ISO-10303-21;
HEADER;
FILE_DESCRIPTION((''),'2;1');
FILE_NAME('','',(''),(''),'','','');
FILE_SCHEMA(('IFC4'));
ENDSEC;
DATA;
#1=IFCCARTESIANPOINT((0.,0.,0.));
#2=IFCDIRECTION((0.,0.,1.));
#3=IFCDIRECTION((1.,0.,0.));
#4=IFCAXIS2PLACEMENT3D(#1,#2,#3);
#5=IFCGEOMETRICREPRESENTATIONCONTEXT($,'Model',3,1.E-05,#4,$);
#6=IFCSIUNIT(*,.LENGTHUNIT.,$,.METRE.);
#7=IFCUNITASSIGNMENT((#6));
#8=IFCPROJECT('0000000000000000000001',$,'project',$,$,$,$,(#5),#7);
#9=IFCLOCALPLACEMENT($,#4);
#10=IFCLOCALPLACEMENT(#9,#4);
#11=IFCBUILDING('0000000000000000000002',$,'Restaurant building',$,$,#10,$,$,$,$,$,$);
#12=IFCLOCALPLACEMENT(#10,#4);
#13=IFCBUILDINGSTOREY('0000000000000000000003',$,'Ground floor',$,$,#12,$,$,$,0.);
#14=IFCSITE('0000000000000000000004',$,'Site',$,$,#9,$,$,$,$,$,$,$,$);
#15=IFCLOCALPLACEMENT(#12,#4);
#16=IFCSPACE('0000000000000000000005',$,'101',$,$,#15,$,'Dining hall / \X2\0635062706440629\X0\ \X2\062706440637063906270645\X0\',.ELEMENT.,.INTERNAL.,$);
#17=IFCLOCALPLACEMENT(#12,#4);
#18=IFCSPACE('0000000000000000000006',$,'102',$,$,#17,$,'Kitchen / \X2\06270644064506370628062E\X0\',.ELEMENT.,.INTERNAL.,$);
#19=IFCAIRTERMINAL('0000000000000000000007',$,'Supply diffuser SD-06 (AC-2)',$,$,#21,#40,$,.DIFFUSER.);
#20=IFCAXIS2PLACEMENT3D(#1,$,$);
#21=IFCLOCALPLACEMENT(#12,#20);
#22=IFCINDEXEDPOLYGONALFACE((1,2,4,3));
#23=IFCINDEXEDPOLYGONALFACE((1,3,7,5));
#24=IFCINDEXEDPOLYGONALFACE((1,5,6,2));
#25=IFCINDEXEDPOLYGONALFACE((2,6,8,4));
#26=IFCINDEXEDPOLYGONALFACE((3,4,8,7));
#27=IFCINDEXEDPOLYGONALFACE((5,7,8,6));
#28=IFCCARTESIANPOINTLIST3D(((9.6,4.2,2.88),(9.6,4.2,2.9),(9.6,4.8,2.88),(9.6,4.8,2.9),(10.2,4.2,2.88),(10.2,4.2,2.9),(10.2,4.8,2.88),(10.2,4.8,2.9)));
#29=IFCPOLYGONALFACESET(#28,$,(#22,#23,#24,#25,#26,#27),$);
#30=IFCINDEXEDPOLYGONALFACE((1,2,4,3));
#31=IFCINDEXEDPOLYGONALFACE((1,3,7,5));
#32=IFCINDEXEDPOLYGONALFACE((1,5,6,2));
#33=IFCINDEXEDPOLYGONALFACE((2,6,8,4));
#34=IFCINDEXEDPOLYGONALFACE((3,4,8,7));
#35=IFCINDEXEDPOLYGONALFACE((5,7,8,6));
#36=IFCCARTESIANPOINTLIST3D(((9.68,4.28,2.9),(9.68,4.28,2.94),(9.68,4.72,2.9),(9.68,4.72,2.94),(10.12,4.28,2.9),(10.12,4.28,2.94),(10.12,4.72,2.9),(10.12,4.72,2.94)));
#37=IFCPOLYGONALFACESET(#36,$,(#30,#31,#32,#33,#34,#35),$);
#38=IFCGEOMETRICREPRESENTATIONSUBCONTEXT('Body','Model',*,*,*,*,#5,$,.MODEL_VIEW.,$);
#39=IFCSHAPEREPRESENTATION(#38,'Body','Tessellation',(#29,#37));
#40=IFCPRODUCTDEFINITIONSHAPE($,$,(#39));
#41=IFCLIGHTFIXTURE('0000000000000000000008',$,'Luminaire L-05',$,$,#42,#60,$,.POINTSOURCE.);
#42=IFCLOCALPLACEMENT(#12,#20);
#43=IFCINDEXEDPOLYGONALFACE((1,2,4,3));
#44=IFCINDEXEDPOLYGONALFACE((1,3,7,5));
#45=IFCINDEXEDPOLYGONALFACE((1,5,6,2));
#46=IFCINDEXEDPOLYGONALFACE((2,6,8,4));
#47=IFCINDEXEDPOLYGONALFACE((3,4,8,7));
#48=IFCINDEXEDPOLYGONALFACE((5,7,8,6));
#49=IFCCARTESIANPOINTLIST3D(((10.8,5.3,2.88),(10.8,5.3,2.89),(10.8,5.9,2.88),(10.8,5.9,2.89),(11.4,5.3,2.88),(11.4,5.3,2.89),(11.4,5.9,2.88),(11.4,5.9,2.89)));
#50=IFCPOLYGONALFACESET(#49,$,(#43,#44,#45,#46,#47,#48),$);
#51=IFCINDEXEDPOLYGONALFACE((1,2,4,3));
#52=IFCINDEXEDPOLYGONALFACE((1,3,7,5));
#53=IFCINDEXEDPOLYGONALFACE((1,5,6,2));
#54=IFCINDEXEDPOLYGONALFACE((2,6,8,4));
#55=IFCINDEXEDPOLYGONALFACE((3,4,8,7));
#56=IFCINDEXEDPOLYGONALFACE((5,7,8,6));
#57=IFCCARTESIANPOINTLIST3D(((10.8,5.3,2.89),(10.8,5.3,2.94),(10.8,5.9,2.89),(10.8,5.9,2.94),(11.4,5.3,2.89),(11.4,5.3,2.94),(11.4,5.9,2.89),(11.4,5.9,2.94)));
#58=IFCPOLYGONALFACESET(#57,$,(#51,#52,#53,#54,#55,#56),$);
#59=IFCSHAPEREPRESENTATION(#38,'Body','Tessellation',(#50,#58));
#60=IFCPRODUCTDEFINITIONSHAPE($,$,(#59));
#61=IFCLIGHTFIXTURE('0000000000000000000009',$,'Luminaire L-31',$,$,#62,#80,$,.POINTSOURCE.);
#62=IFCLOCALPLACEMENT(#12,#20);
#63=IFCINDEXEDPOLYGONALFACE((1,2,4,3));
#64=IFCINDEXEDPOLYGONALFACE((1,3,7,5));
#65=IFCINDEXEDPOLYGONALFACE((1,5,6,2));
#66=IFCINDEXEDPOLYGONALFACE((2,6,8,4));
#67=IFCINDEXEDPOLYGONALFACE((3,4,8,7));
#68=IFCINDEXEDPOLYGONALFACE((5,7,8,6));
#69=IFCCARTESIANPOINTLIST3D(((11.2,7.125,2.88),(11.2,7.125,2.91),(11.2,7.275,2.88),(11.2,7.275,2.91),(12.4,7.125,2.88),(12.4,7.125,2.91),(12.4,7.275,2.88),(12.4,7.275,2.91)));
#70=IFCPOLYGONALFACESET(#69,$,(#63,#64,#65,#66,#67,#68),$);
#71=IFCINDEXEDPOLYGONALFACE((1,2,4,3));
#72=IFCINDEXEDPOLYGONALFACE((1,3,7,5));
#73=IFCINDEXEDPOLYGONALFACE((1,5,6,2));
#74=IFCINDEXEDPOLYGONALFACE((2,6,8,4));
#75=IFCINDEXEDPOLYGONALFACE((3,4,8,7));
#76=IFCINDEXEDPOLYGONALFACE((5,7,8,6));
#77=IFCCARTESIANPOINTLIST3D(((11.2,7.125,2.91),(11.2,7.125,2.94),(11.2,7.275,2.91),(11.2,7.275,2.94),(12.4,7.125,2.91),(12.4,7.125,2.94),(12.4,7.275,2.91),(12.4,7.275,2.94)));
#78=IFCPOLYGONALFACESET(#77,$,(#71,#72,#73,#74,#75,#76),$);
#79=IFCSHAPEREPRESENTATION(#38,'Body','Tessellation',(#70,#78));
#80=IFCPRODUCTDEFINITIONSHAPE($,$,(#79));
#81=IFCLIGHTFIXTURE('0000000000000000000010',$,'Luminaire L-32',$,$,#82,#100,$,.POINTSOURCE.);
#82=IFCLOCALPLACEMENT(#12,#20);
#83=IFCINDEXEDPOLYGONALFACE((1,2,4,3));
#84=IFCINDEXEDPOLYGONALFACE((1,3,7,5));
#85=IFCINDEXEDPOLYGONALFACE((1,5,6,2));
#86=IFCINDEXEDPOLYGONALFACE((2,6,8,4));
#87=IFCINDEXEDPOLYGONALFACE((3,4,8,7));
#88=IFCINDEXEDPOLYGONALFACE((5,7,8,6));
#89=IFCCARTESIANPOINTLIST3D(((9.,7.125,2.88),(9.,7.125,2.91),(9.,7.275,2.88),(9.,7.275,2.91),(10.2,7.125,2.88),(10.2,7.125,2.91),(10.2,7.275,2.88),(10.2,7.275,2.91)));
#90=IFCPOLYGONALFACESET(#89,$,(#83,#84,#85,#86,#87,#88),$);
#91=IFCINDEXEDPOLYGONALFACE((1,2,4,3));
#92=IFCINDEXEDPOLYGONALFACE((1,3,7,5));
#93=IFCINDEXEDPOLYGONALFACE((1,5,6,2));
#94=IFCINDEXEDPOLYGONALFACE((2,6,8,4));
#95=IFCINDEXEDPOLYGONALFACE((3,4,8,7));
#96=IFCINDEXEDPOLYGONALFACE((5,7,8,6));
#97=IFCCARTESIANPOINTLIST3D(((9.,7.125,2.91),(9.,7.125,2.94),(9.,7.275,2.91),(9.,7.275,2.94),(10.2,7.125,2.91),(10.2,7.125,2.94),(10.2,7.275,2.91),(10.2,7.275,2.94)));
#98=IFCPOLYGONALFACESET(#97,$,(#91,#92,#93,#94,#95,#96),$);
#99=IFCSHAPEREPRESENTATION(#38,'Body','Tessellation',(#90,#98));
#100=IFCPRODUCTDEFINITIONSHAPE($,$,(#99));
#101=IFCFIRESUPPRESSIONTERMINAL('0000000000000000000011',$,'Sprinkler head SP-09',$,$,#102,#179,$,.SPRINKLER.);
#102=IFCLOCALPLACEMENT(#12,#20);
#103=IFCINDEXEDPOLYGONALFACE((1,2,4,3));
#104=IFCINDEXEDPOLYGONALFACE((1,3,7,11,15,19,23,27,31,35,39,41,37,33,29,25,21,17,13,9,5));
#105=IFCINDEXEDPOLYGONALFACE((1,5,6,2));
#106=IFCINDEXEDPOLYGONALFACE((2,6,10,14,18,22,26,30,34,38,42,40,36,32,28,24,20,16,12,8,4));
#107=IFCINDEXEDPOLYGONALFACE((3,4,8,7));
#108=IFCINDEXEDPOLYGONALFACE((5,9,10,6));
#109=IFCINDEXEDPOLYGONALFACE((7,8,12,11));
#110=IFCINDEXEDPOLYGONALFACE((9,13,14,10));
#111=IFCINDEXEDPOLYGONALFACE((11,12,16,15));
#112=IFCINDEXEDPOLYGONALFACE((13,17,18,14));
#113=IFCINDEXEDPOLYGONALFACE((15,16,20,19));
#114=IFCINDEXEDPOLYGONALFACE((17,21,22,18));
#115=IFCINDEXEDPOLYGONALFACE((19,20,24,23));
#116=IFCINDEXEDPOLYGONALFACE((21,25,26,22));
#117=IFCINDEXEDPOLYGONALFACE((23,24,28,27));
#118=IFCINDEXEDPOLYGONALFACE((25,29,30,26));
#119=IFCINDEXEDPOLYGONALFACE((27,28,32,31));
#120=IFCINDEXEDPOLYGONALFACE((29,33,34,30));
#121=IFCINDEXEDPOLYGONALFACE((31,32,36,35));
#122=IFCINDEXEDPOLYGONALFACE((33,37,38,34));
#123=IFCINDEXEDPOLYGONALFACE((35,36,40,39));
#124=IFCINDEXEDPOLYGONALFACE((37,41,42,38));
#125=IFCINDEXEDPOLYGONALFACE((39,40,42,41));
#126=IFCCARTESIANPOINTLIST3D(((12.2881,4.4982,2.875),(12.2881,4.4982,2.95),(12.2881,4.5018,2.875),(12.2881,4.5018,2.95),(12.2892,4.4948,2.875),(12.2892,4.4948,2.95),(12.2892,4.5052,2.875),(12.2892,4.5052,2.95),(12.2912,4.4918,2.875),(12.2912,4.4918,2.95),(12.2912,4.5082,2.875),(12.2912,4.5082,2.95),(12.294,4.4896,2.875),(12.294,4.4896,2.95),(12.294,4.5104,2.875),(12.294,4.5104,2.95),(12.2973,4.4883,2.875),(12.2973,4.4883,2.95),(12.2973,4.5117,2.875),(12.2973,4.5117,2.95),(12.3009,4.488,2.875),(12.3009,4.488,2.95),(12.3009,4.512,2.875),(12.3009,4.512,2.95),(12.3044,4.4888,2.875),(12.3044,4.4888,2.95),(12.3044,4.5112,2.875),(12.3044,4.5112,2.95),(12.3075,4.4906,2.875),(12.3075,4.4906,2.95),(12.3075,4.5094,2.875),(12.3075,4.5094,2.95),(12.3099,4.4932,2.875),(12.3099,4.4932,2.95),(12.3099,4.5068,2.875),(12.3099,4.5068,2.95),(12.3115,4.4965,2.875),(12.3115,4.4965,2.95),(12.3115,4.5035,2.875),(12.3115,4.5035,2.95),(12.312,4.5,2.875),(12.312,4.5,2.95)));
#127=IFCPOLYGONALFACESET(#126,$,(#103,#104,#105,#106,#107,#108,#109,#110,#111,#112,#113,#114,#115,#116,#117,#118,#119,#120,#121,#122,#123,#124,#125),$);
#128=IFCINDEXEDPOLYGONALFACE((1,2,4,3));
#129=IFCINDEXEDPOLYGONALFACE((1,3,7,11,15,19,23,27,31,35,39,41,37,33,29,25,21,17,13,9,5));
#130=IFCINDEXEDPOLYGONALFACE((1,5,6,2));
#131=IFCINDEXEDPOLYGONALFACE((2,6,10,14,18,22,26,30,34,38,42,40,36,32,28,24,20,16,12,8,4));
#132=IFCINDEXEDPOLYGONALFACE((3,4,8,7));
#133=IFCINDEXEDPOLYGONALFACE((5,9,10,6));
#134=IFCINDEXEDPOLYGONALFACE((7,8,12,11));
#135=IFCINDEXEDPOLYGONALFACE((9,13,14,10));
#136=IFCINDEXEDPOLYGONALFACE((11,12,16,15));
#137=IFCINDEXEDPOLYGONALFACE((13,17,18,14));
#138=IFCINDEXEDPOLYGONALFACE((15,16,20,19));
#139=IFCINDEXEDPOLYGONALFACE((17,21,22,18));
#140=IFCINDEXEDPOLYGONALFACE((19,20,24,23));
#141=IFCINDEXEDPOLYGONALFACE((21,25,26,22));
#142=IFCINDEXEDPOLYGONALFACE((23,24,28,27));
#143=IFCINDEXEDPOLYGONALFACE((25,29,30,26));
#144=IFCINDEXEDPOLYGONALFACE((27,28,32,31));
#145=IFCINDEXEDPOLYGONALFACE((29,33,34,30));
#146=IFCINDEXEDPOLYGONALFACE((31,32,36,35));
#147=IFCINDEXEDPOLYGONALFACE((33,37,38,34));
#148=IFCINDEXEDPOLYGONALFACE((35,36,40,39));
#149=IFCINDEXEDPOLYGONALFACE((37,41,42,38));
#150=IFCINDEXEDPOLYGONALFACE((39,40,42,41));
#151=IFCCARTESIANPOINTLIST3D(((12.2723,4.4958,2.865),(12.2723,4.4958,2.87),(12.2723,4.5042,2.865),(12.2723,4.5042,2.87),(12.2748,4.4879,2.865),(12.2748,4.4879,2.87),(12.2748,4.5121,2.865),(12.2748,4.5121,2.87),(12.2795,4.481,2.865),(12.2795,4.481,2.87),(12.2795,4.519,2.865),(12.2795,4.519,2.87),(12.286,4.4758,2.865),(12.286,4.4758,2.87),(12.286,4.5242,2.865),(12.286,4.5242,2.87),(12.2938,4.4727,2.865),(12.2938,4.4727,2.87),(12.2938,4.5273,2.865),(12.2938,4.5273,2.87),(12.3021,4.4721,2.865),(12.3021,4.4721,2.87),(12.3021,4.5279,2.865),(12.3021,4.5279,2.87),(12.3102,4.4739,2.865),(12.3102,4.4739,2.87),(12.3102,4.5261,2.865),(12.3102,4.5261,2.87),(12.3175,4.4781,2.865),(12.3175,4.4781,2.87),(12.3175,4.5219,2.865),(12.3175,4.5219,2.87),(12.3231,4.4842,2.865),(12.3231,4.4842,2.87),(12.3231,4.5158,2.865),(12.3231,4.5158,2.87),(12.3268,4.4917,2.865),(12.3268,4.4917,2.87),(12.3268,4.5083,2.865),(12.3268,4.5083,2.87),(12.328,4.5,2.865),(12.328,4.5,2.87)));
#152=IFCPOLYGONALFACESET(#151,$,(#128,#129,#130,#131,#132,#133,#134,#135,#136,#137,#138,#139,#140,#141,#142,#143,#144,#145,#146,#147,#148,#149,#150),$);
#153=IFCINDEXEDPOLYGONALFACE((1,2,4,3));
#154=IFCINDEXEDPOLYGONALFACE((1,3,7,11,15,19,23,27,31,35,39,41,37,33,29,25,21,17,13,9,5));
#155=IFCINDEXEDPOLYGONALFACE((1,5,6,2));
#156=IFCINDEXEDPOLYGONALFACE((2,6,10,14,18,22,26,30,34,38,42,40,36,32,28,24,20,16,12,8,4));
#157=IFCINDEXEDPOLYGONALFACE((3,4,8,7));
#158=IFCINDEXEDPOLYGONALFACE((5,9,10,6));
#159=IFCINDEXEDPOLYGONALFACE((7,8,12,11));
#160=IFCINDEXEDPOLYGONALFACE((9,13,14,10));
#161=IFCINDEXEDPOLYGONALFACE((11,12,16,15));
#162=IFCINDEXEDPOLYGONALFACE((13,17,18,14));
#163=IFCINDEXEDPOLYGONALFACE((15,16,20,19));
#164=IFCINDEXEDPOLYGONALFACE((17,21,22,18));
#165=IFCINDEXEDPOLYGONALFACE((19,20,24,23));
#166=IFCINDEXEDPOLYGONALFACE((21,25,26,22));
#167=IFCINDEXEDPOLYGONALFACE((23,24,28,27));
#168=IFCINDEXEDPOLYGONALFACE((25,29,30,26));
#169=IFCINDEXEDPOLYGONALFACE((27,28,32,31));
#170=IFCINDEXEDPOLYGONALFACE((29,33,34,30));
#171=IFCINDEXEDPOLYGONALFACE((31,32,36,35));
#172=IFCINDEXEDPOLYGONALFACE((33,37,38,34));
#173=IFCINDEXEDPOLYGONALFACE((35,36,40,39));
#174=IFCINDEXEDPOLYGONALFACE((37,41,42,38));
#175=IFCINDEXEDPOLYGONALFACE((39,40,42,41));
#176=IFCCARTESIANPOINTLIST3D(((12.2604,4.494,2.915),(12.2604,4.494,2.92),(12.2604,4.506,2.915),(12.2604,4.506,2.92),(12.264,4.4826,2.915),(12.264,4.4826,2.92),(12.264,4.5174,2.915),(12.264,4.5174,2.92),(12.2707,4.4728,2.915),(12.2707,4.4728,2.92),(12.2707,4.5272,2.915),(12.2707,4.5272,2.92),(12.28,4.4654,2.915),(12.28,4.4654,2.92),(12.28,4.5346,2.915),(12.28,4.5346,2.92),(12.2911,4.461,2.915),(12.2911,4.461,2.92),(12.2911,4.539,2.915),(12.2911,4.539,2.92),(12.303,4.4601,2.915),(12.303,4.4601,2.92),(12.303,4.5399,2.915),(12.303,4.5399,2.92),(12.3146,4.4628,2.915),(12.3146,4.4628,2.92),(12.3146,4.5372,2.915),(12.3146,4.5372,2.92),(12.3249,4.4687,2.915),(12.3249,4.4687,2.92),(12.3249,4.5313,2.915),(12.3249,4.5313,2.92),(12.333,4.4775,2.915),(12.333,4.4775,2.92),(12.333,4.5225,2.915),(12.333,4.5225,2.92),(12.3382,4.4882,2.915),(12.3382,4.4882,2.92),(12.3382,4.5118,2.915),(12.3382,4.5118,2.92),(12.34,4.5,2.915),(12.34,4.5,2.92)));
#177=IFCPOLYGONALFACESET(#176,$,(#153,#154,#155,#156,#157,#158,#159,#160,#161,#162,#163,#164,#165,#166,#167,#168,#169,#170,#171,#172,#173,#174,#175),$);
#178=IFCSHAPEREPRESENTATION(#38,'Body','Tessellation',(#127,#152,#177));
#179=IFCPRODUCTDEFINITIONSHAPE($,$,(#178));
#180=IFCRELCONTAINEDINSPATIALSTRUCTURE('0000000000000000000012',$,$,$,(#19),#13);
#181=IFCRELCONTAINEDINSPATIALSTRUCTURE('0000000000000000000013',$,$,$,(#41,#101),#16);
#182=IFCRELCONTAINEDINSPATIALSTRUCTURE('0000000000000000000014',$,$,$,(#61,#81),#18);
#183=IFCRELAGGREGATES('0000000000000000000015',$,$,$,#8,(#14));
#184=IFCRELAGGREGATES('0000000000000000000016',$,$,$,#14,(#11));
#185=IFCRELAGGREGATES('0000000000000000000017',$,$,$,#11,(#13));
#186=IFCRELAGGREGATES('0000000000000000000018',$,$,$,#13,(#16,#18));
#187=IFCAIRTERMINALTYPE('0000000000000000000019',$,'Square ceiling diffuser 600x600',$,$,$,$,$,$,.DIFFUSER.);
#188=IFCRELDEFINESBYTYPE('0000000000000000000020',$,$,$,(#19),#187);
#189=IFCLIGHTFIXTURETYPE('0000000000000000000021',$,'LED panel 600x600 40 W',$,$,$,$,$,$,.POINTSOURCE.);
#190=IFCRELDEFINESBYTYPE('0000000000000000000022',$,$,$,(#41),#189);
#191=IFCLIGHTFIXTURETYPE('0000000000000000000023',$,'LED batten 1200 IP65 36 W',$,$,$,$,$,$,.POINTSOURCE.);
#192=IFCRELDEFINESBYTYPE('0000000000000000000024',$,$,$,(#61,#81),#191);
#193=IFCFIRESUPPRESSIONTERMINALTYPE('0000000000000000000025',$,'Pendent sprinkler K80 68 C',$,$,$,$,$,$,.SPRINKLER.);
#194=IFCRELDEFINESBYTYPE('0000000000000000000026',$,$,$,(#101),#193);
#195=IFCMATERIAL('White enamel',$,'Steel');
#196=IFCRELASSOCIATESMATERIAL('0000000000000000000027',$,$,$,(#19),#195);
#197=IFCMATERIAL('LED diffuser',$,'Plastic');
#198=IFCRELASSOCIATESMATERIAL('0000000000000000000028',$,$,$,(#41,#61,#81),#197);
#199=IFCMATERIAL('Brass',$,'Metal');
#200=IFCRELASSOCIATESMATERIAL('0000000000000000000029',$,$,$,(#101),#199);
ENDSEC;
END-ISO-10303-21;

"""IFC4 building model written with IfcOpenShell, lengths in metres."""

from ifc_helpers import new_model, si_unit, frame, origin, origin_with_axes, origin_2d, place, context, subcontext, project, spatial, rectangle, circle, extrude, source, transform, mapped, material, type_object, type_shapes, element, save


model = new_model("IFC4")

# Units and contexts
model_context = context("Model", 3, precision=1e-05, world=origin_with_axes())
body_context = subcontext(model_context, "Body", "Model", "MODEL_VIEW")
ifc_project = project(units=[si_unit("LENGTHUNIT", "METRE")], contexts=[model_context])

# Site, building, storey
site_placement = place(None, origin_with_axes())
site = spatial("IfcSite", under=ifc_project, at=site_placement, Name="Site")
building_placement = place(site_placement, origin_with_axes())
building = spatial("IfcBuilding", under=site, at=building_placement, Name="Restaurant building")
storey_placement = place(building_placement, origin_with_axes())
storey = spatial("IfcBuildingStorey", under=building, at=storey_placement, Name="Ground floor", Elevation=0.0)

# Air terminal
ifc_material_1 = material(Name="White enamel", Category="Steel")
air_terminal_type = type_object("IfcAirTerminalType", Name="Square ceiling diffuser 600x600", PredefinedType="DIFFUSER")
shared_shape_1 = source(origin(), body_context, "Body", "SweptSolid", [
    extrude(rectangle(XDim=0.6, YDim=0.6, at=origin_2d()), frame((0.0, 0.0, -0.06)), (0.0, 0.0, 1.0), 0.02),
    extrude(rectangle(XDim=0.44, YDim=0.44, at=origin_2d()), frame((0.0, 0.0, -0.04)), (0.0, 0.0, 1.0), 0.04),
])
type_shapes(air_terminal_type, [shared_shape_1])
air_terminal_placement = place(storey_placement, frame((9.9, 4.5, 2.94)))
element("IfcAirTerminal", 1, at=air_terminal_placement, inside=storey, type_object=air_terminal_type, material=ifc_material_1, Name="Supply diffuser SD-06 (AC-2)", PredefinedType="DIFFUSER", context=body_context, shape_type="MappedRepresentation", body=[
    mapped(shared_shape_1, transform((0.0, 0.0, 0.0))),
])

# Shared definitions
space_1_placement = place(storey_placement, origin_with_axes())
space_1 = spatial("IfcSpace", under=storey, at=space_1_placement, Name="101", LongName="Dining hall / صالة الطعام", CompositionType="ELEMENT", PredefinedType="INTERNAL")

# Light fixture
ifc_material_2 = material(Name="LED diffuser", Category="Plastic")
light_fixture_type_1 = type_object("IfcLightFixtureType", Name="LED panel 600x600 40 W", PredefinedType="POINTSOURCE")
shared_shape_2 = source(origin(), body_context, "Body", "SweptSolid", [
    extrude(rectangle(XDim=0.6, YDim=0.6, at=origin_2d()), frame((0.0, 0.0, -0.06)), (0.0, 0.0, 1.0), 0.01),
    extrude(rectangle(XDim=0.6, YDim=0.6, at=origin_2d()), frame((0.0, 0.0, -0.05)), (0.0, 0.0, 1.0), 0.05),
])
type_shapes(light_fixture_type_1, [shared_shape_2])
light_fixture_placement = place(storey_placement, frame((11.1, 5.6, 2.94)))
element("IfcLightFixture", 2, at=light_fixture_placement, inside=space_1, type_object=light_fixture_type_1, material=ifc_material_2, Name="Luminaire L-05", PredefinedType="POINTSOURCE", context=body_context, shape_type="MappedRepresentation", body=[
    mapped(shared_shape_2, transform((0.0, 0.0, 0.0))),
])

# Shared definitions
space_2_placement = place(storey_placement, origin_with_axes())
space_2 = spatial("IfcSpace", under=storey, at=space_2_placement, Name="102", LongName="Kitchen / المطبخ", CompositionType="ELEMENT", PredefinedType="INTERNAL")

# Light fixtures
light_fixture_type_2 = type_object("IfcLightFixtureType", Name="LED batten 1200 IP65 36 W", PredefinedType="POINTSOURCE")
shared_shape_3 = source(origin(), body_context, "Body", "SweptSolid", [
    extrude(rectangle(XDim=1.2, YDim=0.15, at=origin_2d()), frame((0.0, 0.0, -0.06)), (0.0, 0.0, 1.0), 0.03),
    extrude(rectangle(XDim=1.2, YDim=0.15, at=origin_2d()), frame((0.0, 0.0, -0.03)), (0.0, 0.0, 1.0), 0.03),
])
type_shapes(light_fixture_type_2, [shared_shape_3])
for number, where, name in (
    (3, (11.8, 7.2, 2.94), "Luminaire L-31"),
    (4, (9.6, 7.2, 2.94), "Luminaire L-32"),
):
    element("IfcLightFixture", number, at=place(storey_placement, frame(where)), inside=space_2, type_object=light_fixture_type_2, material=ifc_material_2, Name=name, PredefinedType="POINTSOURCE", context=body_context, shape_type="MappedRepresentation", body=[
        mapped(shared_shape_3, transform((0.0, 0.0, 0.0))),
    ])

# Fire suppression terminal
ifc_material_3 = material(Name="Brass", Category="Metal")
fire_suppression_terminal_type_1 = type_object("IfcFireSuppressionTerminalType", Name="Pendent sprinkler K80 68 C", PredefinedType="SPRINKLER")
shared_shape_4 = source(origin(), body_context, "Body", "SweptSolid", [
    extrude(circle(Radius=0.012, at=origin_2d()), frame((0.0, 0.0, -0.075)), (0.0, 0.0, 1.0), 0.075),
    extrude(circle(Radius=0.028, at=origin_2d()), frame((0.0, 0.0, -0.085)), (0.0, 0.0, 1.0), 0.005),
    extrude(circle(Radius=0.04, at=origin_2d()), frame((0.0, 0.0, -0.035)), (0.0, 0.0, 1.0), 0.005),
])
type_shapes(fire_suppression_terminal_type_1, [shared_shape_4])
fire_suppression_terminal_1_placement = place(storey_placement, frame((12.3, 4.5, 2.95)))
element("IfcFireSuppressionTerminal", 5, at=fire_suppression_terminal_1_placement, inside=space_1, type_object=fire_suppression_terminal_type_1, material=ifc_material_3, Name="Sprinkler head SP-09", PredefinedType="SPRINKLER", context=body_context, shape_type="MappedRepresentation", body=[
    mapped(shared_shape_4, transform((0.0, 0.0, 0.0))),
])

save(model, "model.ifc")
